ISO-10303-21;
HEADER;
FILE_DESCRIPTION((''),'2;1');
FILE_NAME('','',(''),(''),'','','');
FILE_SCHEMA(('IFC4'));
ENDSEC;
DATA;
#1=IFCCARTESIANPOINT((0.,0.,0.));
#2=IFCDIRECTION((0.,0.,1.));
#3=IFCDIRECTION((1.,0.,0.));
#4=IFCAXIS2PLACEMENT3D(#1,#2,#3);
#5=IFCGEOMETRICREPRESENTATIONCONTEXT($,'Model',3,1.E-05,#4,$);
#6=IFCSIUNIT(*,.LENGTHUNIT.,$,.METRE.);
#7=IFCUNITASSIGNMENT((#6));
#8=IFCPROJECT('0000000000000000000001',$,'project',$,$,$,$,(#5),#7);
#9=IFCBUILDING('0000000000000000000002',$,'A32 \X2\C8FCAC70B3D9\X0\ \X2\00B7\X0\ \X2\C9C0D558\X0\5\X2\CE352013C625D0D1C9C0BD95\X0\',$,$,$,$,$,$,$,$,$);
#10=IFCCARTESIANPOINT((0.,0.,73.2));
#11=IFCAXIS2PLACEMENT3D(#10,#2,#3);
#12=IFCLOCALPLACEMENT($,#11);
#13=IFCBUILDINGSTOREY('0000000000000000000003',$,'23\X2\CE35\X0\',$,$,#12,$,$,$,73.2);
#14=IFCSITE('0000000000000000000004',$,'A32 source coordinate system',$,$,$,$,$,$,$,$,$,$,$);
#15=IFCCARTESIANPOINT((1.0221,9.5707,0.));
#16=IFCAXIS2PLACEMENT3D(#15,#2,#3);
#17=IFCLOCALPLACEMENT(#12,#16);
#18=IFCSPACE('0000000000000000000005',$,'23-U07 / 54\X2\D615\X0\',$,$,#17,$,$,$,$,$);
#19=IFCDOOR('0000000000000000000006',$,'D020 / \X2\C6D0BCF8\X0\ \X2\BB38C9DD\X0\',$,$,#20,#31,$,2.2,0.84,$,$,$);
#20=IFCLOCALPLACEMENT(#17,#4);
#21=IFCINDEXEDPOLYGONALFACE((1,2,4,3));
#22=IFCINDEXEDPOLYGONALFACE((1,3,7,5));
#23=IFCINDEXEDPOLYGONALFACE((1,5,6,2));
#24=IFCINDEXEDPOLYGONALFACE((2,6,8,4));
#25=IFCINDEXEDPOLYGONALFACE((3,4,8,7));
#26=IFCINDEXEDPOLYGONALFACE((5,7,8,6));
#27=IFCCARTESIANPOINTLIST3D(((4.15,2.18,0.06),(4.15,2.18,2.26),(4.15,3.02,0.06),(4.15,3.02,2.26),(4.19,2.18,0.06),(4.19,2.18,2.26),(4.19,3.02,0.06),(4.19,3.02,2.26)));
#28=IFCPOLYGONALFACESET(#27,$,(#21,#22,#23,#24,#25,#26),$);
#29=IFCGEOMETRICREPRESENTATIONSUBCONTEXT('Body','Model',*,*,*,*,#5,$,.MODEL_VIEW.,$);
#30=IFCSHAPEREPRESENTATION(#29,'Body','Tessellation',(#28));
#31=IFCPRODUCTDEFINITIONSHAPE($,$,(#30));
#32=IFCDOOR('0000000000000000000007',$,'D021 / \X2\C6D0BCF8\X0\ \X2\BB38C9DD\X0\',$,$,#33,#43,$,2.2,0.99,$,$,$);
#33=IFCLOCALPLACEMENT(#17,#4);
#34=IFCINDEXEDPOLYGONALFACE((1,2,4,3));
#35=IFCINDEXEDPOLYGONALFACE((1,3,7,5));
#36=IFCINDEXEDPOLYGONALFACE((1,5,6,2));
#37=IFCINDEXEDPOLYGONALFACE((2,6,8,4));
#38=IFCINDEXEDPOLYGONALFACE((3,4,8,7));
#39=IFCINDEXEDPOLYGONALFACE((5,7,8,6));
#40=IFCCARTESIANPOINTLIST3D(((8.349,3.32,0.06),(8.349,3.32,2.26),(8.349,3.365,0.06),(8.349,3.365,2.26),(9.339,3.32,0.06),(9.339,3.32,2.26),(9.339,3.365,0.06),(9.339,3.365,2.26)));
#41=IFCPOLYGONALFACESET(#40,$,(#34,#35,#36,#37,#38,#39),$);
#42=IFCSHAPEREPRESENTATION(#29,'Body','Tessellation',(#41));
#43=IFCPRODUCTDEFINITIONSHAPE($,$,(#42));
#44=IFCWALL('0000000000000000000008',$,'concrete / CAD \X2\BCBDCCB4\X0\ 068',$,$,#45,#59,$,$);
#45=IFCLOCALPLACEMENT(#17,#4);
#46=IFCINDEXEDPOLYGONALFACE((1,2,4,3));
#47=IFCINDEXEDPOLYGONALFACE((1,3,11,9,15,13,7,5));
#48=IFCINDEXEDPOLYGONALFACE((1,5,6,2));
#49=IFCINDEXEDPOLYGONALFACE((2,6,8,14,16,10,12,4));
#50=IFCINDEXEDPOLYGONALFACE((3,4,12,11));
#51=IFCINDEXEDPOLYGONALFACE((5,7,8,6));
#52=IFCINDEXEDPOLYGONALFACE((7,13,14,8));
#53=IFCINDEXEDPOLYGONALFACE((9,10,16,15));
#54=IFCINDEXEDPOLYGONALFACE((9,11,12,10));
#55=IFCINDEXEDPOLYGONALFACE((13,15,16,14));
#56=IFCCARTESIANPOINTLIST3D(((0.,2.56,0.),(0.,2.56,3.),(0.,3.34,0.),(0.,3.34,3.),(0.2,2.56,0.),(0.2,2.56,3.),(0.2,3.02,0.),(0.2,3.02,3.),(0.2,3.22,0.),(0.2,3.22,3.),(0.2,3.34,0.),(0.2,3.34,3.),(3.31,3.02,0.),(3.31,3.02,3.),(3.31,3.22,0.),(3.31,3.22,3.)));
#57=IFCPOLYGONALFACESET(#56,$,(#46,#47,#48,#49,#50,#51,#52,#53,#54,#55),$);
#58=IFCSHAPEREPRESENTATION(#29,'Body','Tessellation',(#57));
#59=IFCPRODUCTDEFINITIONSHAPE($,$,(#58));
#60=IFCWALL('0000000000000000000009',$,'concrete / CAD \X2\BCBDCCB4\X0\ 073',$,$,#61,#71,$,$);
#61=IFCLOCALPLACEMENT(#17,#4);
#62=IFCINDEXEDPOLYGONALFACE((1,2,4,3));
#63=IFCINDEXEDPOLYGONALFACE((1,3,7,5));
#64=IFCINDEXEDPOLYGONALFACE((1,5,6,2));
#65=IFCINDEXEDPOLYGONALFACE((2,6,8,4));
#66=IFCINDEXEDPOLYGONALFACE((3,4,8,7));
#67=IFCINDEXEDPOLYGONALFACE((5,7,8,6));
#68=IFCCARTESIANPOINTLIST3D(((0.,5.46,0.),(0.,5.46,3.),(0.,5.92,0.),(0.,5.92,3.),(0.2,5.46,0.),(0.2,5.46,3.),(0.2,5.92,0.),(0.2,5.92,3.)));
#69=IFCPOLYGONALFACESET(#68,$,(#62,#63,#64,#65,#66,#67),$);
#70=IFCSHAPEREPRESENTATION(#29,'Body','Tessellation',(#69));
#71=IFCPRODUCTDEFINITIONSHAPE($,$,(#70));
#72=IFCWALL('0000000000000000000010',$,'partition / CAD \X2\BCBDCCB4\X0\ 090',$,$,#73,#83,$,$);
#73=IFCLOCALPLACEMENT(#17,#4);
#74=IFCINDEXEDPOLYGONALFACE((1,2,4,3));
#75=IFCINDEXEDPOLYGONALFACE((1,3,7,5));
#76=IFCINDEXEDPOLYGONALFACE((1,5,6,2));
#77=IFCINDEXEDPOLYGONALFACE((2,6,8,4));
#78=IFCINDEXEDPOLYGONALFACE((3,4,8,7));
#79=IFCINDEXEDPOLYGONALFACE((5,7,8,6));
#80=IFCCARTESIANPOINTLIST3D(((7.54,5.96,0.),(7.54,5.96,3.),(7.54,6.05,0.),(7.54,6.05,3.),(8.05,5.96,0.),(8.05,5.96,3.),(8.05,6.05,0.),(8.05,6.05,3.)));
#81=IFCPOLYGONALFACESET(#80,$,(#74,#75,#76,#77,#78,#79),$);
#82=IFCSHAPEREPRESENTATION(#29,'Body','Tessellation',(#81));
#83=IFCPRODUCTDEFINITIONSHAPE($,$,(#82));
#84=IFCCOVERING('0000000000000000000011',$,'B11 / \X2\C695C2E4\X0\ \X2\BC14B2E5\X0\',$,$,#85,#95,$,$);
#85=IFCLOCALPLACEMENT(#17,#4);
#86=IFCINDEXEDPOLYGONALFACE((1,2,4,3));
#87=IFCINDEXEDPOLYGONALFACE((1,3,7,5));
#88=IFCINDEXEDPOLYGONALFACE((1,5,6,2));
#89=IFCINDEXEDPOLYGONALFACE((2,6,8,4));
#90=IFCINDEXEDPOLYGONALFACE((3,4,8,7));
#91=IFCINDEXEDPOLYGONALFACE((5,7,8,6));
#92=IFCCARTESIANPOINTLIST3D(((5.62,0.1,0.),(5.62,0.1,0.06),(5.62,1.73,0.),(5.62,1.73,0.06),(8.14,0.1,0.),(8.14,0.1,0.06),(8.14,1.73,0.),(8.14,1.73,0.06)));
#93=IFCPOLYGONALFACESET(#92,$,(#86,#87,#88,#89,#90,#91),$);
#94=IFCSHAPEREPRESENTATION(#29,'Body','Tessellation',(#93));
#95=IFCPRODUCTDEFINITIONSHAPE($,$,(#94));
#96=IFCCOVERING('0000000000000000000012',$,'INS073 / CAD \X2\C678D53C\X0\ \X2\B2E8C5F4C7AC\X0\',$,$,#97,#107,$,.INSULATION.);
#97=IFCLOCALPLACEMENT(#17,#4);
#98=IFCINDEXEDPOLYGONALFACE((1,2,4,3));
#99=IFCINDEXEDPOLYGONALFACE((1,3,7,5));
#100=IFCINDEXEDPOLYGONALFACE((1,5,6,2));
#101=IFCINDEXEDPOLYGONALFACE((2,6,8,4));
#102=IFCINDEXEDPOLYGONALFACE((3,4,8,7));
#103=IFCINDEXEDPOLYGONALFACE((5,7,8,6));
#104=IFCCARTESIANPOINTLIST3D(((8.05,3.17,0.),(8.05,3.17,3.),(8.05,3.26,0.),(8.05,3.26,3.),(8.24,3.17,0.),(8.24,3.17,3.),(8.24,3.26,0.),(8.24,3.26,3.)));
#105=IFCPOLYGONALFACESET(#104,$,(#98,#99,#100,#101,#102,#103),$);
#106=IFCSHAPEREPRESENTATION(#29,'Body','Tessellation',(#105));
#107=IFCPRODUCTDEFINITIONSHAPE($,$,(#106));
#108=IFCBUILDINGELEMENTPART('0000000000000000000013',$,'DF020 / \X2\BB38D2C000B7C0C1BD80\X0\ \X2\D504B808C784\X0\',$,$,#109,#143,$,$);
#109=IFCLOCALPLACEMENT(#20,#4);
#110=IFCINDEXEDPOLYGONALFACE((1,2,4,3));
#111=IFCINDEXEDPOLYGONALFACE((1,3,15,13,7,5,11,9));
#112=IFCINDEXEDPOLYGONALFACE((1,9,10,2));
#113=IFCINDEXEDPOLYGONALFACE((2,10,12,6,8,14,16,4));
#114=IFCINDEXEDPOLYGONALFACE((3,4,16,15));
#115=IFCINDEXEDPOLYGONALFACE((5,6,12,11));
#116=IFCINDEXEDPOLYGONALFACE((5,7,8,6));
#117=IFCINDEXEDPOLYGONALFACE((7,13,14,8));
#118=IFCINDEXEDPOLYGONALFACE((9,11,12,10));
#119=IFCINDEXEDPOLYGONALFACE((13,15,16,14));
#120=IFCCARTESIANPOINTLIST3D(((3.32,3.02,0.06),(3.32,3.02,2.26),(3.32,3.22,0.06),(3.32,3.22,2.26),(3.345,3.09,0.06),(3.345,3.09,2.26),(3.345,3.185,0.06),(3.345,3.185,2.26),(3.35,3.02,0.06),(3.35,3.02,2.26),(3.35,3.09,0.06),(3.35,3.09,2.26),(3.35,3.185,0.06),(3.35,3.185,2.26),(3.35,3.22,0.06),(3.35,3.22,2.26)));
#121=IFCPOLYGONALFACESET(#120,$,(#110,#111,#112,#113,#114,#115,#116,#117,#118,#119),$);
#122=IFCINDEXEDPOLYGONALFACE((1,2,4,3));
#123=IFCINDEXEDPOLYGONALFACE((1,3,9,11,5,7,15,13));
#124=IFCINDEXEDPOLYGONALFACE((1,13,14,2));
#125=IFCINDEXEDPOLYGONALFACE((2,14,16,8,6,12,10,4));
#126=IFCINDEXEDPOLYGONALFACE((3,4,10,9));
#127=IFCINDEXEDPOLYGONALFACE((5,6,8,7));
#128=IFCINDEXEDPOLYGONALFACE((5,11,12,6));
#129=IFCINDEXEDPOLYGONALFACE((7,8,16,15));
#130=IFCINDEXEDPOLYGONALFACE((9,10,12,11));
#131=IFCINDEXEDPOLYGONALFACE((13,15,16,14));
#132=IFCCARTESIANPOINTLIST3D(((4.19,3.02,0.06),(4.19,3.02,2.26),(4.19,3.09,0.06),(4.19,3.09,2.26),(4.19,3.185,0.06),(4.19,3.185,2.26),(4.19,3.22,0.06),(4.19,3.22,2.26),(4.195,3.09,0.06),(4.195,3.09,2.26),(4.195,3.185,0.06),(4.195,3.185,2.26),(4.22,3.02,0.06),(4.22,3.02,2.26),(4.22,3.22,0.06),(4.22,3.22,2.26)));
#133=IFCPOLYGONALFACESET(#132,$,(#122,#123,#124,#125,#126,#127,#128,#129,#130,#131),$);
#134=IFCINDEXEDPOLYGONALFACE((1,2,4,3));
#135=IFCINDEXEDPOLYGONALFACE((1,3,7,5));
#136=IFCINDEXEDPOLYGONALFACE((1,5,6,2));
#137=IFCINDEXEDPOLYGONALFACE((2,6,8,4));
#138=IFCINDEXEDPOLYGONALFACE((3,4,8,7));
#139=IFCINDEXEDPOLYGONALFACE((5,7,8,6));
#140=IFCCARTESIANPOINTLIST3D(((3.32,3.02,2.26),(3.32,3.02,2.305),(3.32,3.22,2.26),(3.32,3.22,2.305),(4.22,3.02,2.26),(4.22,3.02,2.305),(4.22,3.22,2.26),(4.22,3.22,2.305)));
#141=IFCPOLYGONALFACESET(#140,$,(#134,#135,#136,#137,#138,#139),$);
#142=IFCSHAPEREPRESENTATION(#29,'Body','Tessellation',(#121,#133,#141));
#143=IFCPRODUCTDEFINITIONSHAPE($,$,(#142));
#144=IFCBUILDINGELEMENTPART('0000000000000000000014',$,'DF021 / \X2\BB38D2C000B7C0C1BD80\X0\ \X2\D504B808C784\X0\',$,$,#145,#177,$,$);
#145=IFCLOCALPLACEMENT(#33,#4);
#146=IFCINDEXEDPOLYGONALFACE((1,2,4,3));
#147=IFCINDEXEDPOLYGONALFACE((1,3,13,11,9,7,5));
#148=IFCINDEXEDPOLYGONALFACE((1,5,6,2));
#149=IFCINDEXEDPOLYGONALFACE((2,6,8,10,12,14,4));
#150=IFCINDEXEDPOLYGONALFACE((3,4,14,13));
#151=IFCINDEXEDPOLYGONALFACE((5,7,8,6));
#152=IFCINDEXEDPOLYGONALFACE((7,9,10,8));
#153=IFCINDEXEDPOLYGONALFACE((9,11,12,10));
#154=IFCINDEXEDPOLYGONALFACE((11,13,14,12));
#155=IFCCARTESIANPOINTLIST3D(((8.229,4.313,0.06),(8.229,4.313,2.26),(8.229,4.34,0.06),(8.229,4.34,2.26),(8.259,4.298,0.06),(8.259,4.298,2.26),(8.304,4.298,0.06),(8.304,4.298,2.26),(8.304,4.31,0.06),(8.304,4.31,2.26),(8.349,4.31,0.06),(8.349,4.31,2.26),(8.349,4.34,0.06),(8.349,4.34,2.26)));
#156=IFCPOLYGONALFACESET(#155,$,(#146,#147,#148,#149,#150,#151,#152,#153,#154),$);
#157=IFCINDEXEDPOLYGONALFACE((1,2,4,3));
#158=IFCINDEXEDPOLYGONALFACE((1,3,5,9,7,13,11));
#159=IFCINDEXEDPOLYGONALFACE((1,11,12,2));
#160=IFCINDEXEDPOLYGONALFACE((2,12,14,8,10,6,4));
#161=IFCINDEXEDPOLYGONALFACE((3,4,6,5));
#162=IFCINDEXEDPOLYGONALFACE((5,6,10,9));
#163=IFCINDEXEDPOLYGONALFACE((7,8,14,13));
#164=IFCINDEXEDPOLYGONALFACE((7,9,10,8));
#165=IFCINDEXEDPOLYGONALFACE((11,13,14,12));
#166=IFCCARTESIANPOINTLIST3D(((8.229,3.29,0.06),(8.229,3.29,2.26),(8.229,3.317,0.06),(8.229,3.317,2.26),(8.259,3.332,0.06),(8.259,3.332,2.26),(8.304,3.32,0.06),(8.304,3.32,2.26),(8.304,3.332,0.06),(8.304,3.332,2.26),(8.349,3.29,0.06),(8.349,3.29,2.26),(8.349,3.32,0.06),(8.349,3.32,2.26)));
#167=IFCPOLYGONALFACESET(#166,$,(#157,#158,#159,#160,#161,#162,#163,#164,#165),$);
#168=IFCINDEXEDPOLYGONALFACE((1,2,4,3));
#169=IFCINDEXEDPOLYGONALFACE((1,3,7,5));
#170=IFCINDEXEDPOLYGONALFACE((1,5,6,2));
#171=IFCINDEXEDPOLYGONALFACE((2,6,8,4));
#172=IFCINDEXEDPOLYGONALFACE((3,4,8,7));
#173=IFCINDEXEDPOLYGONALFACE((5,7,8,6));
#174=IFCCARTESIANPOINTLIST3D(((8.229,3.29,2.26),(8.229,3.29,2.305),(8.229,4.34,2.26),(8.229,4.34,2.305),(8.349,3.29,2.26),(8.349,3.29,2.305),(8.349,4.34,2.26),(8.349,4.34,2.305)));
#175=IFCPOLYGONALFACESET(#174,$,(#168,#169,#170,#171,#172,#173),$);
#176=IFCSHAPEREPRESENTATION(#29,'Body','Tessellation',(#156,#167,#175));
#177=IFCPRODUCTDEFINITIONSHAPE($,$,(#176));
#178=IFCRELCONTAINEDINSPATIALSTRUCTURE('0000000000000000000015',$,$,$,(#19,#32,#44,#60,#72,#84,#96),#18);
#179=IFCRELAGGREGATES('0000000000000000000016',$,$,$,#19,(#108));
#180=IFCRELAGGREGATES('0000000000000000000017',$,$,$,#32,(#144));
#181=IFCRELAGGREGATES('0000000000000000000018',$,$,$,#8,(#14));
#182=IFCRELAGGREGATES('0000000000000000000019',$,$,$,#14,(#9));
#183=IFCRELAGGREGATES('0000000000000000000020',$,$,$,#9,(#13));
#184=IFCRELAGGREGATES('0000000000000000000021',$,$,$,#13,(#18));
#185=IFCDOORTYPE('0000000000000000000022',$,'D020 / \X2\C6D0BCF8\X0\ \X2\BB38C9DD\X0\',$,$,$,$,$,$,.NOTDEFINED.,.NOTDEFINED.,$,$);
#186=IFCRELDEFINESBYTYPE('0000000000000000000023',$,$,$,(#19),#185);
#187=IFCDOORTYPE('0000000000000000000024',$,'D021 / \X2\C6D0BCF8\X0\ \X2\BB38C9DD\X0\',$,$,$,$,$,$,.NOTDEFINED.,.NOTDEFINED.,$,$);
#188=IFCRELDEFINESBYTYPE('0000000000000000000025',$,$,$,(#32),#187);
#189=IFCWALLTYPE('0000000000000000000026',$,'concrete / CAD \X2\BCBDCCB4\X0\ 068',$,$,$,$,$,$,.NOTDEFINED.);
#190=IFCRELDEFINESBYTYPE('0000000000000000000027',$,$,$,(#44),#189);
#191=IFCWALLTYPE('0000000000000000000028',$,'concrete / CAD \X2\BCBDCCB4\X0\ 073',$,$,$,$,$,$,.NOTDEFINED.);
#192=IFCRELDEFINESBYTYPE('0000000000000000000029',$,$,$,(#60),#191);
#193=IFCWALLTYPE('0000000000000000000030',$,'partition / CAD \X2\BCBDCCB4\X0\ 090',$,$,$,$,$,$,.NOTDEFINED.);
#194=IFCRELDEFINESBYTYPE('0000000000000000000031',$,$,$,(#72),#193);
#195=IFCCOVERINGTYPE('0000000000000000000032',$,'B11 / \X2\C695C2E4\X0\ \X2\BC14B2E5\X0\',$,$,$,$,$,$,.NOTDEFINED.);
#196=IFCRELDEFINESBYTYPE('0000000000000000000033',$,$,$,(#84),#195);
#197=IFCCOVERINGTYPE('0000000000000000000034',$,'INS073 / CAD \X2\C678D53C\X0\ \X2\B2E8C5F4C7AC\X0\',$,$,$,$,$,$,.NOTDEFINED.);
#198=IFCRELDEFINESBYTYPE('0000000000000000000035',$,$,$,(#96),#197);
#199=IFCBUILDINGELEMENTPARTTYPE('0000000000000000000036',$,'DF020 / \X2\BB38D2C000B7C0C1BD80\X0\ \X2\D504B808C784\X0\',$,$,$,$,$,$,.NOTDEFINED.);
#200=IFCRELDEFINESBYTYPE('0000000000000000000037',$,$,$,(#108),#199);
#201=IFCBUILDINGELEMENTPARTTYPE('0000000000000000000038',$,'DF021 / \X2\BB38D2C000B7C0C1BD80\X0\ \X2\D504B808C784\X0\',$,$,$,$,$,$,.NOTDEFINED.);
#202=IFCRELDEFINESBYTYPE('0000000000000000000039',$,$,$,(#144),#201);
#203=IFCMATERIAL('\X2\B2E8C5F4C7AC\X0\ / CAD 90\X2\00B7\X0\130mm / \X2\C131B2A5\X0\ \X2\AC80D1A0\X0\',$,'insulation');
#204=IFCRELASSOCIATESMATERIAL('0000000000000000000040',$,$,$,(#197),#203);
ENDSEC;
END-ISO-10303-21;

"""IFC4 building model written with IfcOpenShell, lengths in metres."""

from ifc_helpers import new_model, si_unit, frame, origin, origin_with_axes, place, context, subcontext, project, spatial, polyline, outline, extrude, source, transform, mapped, material, type_object, type_shapes, element, aggregate, save


model = new_model("IFC4")

# Units and contexts
model_context = context("Model", 3, precision=1e-05, world=origin_with_axes())
body_context = subcontext(model_context, "Body", "Model", "MODEL_VIEW")
ifc_project = project(units=[si_unit("LENGTHUNIT", "METRE")], contexts=[model_context])

# Site, building, storey, space
storey_placement = place(None, frame((0.0, 0.0, 73.2), z_axis=(0.0, 0.0, 1.0), x_axis=(1.0, 0.0, 0.0)))
space_placement = place(storey_placement, frame((1.0221, 9.5707, 0.0), z_axis=(0.0, 0.0, 1.0), x_axis=(1.0, 0.0, 0.0)))
site = spatial("IfcSite", under=ifc_project, Name="A32 source coordinate system")
building = spatial("IfcBuilding", under=site, Name="A32 주거동 · 지하5층–옥탑지붕")
storey = spatial("IfcBuildingStorey", under=building, at=storey_placement, Name="23층", Elevation=73.2)
space = spatial("IfcSpace", under=storey, at=space_placement, Name="23-U07 / 54형")

# Doors
door_type_1 = type_object("IfcDoorType", Name="D020 / 원본 문짝", OperationType="NOTDEFINED", PredefinedType="NOTDEFINED")
shared_shape_1 = source(origin(), body_context, "Body", "SweptSolid", [
    extrude(outline(polyline([(4.19, 3.02), (4.19, 2.18), (4.15, 2.18), (4.15, 3.02), (4.19, 3.02)])), frame((0.0, 0.0, 0.06)), (0.0, 0.0, 1.0), 2.2),
])
type_shapes(door_type_1, [shared_shape_1])
door_1_placement = place(space_placement, origin_with_axes())
door_1 = element("IfcDoor", 1, at=door_1_placement, inside=space, type_object=door_type_1, Name="D020 / 원본 문짝", OverallHeight=2.2, OverallWidth=0.84, context=body_context, shape_type="MappedRepresentation", body=[
    mapped(shared_shape_1, transform((0.0, 0.0, 0.0), scale=1.0)),
])
door_type_2 = type_object("IfcDoorType", Name="D021 / 원본 문짝", OperationType="NOTDEFINED", PredefinedType="NOTDEFINED")
shared_shape_2 = source(origin(), body_context, "Body", "SweptSolid", [
    extrude(outline(polyline([(9.339, 3.365), (9.339, 3.32), (8.349, 3.32), (8.349, 3.365), (9.339, 3.365)])), frame((0.0, 0.0, 0.06)), (0.0, 0.0, 1.0), 2.2),
])
type_shapes(door_type_2, [shared_shape_2])
door_2_placement = place(space_placement, origin_with_axes())
door_2 = element("IfcDoor", 2, at=door_2_placement, inside=space, type_object=door_type_2, Name="D021 / 원본 문짝", OverallHeight=2.2, OverallWidth=0.99, context=body_context, shape_type="MappedRepresentation", body=[
    mapped(shared_shape_2, transform((0.0, 0.0, 0.0), scale=1.0)),
])

# Walls
wall_type_1 = type_object("IfcWallType", Name="concrete / CAD 벽체 068", PredefinedType="NOTDEFINED")
shared_shape_3 = source(origin(), body_context, "Body", "SweptSolid", [
    extrude(outline(polyline([(0.2, 3.02), (0.2, 2.56), (0.0, 2.56), (0.0, 3.34), (0.2, 3.34), (0.2, 3.22), (3.31, 3.22), (3.31, 3.02), (0.2, 3.02)])), origin(), (0.0, 0.0, 1.0), 3.0),
])
type_shapes(wall_type_1, [shared_shape_3])
wall_1_placement = place(space_placement, origin_with_axes())
element("IfcWall", 3, at=wall_1_placement, inside=space, type_object=wall_type_1, Name="concrete / CAD 벽체 068", context=body_context, shape_type="MappedRepresentation", body=[
    mapped(shared_shape_3, transform((0.0, 0.0, 0.0), scale=1.0)),
])
wall_type_2 = type_object("IfcWallType", Name="concrete / CAD 벽체 073", PredefinedType="NOTDEFINED")
shared_shape_4 = source(origin(), body_context, "Body", "SweptSolid", [
    extrude(outline(polyline([(0.2, 5.92), (0.2, 5.46), (0.0, 5.46), (0.0, 5.92), (0.2, 5.92)])), origin(), (0.0, 0.0, 1.0), 3.0),
])
type_shapes(wall_type_2, [shared_shape_4])
wall_2_placement = place(space_placement, origin_with_axes())
element("IfcWall", 4, at=wall_2_placement, inside=space, type_object=wall_type_2, Name="concrete / CAD 벽체 073", context=body_context, shape_type="MappedRepresentation", body=[
    mapped(shared_shape_4, transform((0.0, 0.0, 0.0), scale=1.0)),
])
wall_type_3 = type_object("IfcWallType", Name="partition / CAD 벽체 090", PredefinedType="NOTDEFINED")
shared_shape_5 = source(origin(), body_context, "Body", "SweptSolid", [
    extrude(outline(polyline([(7.54, 5.96), (7.54, 6.05), (8.05, 6.05), (8.05, 5.96), (7.54, 5.96)])), origin(), (0.0, 0.0, 1.0), 3.0),
])
type_shapes(wall_type_3, [shared_shape_5])
wall_3_placement = place(space_placement, origin_with_axes())
element("IfcWall", 5, at=wall_3_placement, inside=space, type_object=wall_type_3, Name="partition / CAD 벽체 090", context=body_context, shape_type="MappedRepresentation", body=[
    mapped(shared_shape_5, transform((0.0, 0.0, 0.0), scale=1.0)),
])

# Coverings
covering_type_1 = type_object("IfcCoveringType", Name="B11 / 욕실 바닥", PredefinedType="NOTDEFINED")
shared_shape_6 = source(origin(), body_context, "Body", "SweptSolid", [
    extrude(outline(polyline([(8.14, 1.73), (8.14, 0.1), (5.62, 0.1), (5.62, 1.73), (8.14, 1.73)])), origin(), (0.0, 0.0, 1.0), 0.06),
])
type_shapes(covering_type_1, [shared_shape_6])
covering_1_placement = place(space_placement, origin_with_axes())
element("IfcCovering", 6, at=covering_1_placement, inside=space, type_object=covering_type_1, Name="B11 / 욕실 바닥", context=body_context, shape_type="MappedRepresentation", body=[
    mapped(shared_shape_6, transform((0.0, 0.0, 0.0), scale=1.0)),
])
ifc_material = material(Name="단열재 / CAD 90·130mm / 성능 검토", Category="insulation")
covering_type_2 = type_object("IfcCoveringType", Name="INS073 / CAD 외피 단열재", PredefinedType="NOTDEFINED", material=ifc_material)
shared_shape_7 = source(origin(), body_context, "Body", "SweptSolid", [
    extrude(outline(polyline([(8.05, 3.17), (8.05, 3.26), (8.24, 3.26), (8.24, 3.17), (8.05, 3.17)])), origin(), (0.0, 0.0, 1.0), 3.0),
])
type_shapes(covering_type_2, [shared_shape_7])
covering_2_placement = place(space_placement, origin_with_axes())
element("IfcCovering", 7, at=covering_2_placement, inside=space, type_object=covering_type_2, Name="INS073 / CAD 외피 단열재", PredefinedType="INSULATION", context=body_context, shape_type="MappedRepresentation", body=[
    mapped(shared_shape_7, transform((0.0, 0.0, 0.0), scale=1.0)),
])

# Building element parts
building_element_part_type_1 = type_object("IfcBuildingElementPartType", Name="DF020 / 문틀·상부 프레임", PredefinedType="NOTDEFINED")
shared_shape_8 = source(origin(), body_context, "Body", "SweptSolid", [
    extrude(outline(polyline([(3.32, 3.22), (3.35, 3.22), (3.35, 3.185), (3.345, 3.185), (3.345, 3.09), (3.35, 3.09), (3.35, 3.02), (3.32, 3.02), (3.32, 3.22)])), frame((0.0, 0.0, 0.06)), (0.0, 0.0, 1.0), 2.2),
    extrude(outline(polyline([(4.19, 3.02), (4.19, 3.09), (4.195, 3.09), (4.195, 3.185), (4.19, 3.185), (4.19, 3.22), (4.22, 3.22), (4.22, 3.02), (4.19, 3.02)])), frame((0.0, 0.0, 0.06)), (0.0, 0.0, 1.0), 2.2),
    extrude(outline(polyline([(3.32, 3.02), (3.32, 3.22), (4.22, 3.22), (4.22, 3.02), (3.32, 3.02)])), frame((0.0, 0.0, 2.26)), (0.0, 0.0, 1.0), 0.045),
])
type_shapes(building_element_part_type_1, [shared_shape_8])
building_element_part_1_placement = place(door_1_placement, origin_with_axes())
building_element_part_1 = element("IfcBuildingElementPart", 8, at=building_element_part_1_placement, type_object=building_element_part_type_1, Name="DF020 / 문틀·상부 프레임", context=body_context, shape_type="MappedRepresentation", body=[
    mapped(shared_shape_8, transform((0.0, 0.0, 0.0), scale=1.0)),
])
aggregate(door_1, [building_element_part_1])
building_element_part_type_2 = type_object("IfcBuildingElementPartType", Name="DF021 / 문틀·상부 프레임", PredefinedType="NOTDEFINED")
shared_shape_9 = source(origin(), body_context, "Body", "SweptSolid", [
    extrude(outline(polyline([(8.349, 4.31), (8.304, 4.31), (8.304, 4.298), (8.259, 4.298), (8.229, 4.313), (8.229, 4.34), (8.349, 4.34), (8.349, 4.31)])), frame((0.0, 0.0, 0.06)), (0.0, 0.0, 1.0), 2.2),
    extrude(outline(polyline([(8.229, 3.29), (8.229, 3.317), (8.259, 3.332), (8.304, 3.332), (8.304, 3.32), (8.349, 3.32), (8.349, 3.29), (8.229, 3.29)])), frame((0.0, 0.0, 0.06)), (0.0, 0.0, 1.0), 2.2),
    extrude(outline(polyline([(8.229, 3.29), (8.229, 4.34), (8.349, 4.34), (8.349, 3.29), (8.229, 3.29)])), frame((0.0, 0.0, 2.26)), (0.0, 0.0, 1.0), 0.045),
])
type_shapes(building_element_part_type_2, [shared_shape_9])
building_element_part_2_placement = place(door_2_placement, origin_with_axes())
building_element_part_2 = element("IfcBuildingElementPart", 9, at=building_element_part_2_placement, type_object=building_element_part_type_2, Name="DF021 / 문틀·상부 프레임", context=body_context, shape_type="MappedRepresentation", body=[
    mapped(shared_shape_9, transform((0.0, 0.0, 0.0), scale=1.0)),
])
aggregate(door_2, [building_element_part_2])

save(model, "model.ifc")
